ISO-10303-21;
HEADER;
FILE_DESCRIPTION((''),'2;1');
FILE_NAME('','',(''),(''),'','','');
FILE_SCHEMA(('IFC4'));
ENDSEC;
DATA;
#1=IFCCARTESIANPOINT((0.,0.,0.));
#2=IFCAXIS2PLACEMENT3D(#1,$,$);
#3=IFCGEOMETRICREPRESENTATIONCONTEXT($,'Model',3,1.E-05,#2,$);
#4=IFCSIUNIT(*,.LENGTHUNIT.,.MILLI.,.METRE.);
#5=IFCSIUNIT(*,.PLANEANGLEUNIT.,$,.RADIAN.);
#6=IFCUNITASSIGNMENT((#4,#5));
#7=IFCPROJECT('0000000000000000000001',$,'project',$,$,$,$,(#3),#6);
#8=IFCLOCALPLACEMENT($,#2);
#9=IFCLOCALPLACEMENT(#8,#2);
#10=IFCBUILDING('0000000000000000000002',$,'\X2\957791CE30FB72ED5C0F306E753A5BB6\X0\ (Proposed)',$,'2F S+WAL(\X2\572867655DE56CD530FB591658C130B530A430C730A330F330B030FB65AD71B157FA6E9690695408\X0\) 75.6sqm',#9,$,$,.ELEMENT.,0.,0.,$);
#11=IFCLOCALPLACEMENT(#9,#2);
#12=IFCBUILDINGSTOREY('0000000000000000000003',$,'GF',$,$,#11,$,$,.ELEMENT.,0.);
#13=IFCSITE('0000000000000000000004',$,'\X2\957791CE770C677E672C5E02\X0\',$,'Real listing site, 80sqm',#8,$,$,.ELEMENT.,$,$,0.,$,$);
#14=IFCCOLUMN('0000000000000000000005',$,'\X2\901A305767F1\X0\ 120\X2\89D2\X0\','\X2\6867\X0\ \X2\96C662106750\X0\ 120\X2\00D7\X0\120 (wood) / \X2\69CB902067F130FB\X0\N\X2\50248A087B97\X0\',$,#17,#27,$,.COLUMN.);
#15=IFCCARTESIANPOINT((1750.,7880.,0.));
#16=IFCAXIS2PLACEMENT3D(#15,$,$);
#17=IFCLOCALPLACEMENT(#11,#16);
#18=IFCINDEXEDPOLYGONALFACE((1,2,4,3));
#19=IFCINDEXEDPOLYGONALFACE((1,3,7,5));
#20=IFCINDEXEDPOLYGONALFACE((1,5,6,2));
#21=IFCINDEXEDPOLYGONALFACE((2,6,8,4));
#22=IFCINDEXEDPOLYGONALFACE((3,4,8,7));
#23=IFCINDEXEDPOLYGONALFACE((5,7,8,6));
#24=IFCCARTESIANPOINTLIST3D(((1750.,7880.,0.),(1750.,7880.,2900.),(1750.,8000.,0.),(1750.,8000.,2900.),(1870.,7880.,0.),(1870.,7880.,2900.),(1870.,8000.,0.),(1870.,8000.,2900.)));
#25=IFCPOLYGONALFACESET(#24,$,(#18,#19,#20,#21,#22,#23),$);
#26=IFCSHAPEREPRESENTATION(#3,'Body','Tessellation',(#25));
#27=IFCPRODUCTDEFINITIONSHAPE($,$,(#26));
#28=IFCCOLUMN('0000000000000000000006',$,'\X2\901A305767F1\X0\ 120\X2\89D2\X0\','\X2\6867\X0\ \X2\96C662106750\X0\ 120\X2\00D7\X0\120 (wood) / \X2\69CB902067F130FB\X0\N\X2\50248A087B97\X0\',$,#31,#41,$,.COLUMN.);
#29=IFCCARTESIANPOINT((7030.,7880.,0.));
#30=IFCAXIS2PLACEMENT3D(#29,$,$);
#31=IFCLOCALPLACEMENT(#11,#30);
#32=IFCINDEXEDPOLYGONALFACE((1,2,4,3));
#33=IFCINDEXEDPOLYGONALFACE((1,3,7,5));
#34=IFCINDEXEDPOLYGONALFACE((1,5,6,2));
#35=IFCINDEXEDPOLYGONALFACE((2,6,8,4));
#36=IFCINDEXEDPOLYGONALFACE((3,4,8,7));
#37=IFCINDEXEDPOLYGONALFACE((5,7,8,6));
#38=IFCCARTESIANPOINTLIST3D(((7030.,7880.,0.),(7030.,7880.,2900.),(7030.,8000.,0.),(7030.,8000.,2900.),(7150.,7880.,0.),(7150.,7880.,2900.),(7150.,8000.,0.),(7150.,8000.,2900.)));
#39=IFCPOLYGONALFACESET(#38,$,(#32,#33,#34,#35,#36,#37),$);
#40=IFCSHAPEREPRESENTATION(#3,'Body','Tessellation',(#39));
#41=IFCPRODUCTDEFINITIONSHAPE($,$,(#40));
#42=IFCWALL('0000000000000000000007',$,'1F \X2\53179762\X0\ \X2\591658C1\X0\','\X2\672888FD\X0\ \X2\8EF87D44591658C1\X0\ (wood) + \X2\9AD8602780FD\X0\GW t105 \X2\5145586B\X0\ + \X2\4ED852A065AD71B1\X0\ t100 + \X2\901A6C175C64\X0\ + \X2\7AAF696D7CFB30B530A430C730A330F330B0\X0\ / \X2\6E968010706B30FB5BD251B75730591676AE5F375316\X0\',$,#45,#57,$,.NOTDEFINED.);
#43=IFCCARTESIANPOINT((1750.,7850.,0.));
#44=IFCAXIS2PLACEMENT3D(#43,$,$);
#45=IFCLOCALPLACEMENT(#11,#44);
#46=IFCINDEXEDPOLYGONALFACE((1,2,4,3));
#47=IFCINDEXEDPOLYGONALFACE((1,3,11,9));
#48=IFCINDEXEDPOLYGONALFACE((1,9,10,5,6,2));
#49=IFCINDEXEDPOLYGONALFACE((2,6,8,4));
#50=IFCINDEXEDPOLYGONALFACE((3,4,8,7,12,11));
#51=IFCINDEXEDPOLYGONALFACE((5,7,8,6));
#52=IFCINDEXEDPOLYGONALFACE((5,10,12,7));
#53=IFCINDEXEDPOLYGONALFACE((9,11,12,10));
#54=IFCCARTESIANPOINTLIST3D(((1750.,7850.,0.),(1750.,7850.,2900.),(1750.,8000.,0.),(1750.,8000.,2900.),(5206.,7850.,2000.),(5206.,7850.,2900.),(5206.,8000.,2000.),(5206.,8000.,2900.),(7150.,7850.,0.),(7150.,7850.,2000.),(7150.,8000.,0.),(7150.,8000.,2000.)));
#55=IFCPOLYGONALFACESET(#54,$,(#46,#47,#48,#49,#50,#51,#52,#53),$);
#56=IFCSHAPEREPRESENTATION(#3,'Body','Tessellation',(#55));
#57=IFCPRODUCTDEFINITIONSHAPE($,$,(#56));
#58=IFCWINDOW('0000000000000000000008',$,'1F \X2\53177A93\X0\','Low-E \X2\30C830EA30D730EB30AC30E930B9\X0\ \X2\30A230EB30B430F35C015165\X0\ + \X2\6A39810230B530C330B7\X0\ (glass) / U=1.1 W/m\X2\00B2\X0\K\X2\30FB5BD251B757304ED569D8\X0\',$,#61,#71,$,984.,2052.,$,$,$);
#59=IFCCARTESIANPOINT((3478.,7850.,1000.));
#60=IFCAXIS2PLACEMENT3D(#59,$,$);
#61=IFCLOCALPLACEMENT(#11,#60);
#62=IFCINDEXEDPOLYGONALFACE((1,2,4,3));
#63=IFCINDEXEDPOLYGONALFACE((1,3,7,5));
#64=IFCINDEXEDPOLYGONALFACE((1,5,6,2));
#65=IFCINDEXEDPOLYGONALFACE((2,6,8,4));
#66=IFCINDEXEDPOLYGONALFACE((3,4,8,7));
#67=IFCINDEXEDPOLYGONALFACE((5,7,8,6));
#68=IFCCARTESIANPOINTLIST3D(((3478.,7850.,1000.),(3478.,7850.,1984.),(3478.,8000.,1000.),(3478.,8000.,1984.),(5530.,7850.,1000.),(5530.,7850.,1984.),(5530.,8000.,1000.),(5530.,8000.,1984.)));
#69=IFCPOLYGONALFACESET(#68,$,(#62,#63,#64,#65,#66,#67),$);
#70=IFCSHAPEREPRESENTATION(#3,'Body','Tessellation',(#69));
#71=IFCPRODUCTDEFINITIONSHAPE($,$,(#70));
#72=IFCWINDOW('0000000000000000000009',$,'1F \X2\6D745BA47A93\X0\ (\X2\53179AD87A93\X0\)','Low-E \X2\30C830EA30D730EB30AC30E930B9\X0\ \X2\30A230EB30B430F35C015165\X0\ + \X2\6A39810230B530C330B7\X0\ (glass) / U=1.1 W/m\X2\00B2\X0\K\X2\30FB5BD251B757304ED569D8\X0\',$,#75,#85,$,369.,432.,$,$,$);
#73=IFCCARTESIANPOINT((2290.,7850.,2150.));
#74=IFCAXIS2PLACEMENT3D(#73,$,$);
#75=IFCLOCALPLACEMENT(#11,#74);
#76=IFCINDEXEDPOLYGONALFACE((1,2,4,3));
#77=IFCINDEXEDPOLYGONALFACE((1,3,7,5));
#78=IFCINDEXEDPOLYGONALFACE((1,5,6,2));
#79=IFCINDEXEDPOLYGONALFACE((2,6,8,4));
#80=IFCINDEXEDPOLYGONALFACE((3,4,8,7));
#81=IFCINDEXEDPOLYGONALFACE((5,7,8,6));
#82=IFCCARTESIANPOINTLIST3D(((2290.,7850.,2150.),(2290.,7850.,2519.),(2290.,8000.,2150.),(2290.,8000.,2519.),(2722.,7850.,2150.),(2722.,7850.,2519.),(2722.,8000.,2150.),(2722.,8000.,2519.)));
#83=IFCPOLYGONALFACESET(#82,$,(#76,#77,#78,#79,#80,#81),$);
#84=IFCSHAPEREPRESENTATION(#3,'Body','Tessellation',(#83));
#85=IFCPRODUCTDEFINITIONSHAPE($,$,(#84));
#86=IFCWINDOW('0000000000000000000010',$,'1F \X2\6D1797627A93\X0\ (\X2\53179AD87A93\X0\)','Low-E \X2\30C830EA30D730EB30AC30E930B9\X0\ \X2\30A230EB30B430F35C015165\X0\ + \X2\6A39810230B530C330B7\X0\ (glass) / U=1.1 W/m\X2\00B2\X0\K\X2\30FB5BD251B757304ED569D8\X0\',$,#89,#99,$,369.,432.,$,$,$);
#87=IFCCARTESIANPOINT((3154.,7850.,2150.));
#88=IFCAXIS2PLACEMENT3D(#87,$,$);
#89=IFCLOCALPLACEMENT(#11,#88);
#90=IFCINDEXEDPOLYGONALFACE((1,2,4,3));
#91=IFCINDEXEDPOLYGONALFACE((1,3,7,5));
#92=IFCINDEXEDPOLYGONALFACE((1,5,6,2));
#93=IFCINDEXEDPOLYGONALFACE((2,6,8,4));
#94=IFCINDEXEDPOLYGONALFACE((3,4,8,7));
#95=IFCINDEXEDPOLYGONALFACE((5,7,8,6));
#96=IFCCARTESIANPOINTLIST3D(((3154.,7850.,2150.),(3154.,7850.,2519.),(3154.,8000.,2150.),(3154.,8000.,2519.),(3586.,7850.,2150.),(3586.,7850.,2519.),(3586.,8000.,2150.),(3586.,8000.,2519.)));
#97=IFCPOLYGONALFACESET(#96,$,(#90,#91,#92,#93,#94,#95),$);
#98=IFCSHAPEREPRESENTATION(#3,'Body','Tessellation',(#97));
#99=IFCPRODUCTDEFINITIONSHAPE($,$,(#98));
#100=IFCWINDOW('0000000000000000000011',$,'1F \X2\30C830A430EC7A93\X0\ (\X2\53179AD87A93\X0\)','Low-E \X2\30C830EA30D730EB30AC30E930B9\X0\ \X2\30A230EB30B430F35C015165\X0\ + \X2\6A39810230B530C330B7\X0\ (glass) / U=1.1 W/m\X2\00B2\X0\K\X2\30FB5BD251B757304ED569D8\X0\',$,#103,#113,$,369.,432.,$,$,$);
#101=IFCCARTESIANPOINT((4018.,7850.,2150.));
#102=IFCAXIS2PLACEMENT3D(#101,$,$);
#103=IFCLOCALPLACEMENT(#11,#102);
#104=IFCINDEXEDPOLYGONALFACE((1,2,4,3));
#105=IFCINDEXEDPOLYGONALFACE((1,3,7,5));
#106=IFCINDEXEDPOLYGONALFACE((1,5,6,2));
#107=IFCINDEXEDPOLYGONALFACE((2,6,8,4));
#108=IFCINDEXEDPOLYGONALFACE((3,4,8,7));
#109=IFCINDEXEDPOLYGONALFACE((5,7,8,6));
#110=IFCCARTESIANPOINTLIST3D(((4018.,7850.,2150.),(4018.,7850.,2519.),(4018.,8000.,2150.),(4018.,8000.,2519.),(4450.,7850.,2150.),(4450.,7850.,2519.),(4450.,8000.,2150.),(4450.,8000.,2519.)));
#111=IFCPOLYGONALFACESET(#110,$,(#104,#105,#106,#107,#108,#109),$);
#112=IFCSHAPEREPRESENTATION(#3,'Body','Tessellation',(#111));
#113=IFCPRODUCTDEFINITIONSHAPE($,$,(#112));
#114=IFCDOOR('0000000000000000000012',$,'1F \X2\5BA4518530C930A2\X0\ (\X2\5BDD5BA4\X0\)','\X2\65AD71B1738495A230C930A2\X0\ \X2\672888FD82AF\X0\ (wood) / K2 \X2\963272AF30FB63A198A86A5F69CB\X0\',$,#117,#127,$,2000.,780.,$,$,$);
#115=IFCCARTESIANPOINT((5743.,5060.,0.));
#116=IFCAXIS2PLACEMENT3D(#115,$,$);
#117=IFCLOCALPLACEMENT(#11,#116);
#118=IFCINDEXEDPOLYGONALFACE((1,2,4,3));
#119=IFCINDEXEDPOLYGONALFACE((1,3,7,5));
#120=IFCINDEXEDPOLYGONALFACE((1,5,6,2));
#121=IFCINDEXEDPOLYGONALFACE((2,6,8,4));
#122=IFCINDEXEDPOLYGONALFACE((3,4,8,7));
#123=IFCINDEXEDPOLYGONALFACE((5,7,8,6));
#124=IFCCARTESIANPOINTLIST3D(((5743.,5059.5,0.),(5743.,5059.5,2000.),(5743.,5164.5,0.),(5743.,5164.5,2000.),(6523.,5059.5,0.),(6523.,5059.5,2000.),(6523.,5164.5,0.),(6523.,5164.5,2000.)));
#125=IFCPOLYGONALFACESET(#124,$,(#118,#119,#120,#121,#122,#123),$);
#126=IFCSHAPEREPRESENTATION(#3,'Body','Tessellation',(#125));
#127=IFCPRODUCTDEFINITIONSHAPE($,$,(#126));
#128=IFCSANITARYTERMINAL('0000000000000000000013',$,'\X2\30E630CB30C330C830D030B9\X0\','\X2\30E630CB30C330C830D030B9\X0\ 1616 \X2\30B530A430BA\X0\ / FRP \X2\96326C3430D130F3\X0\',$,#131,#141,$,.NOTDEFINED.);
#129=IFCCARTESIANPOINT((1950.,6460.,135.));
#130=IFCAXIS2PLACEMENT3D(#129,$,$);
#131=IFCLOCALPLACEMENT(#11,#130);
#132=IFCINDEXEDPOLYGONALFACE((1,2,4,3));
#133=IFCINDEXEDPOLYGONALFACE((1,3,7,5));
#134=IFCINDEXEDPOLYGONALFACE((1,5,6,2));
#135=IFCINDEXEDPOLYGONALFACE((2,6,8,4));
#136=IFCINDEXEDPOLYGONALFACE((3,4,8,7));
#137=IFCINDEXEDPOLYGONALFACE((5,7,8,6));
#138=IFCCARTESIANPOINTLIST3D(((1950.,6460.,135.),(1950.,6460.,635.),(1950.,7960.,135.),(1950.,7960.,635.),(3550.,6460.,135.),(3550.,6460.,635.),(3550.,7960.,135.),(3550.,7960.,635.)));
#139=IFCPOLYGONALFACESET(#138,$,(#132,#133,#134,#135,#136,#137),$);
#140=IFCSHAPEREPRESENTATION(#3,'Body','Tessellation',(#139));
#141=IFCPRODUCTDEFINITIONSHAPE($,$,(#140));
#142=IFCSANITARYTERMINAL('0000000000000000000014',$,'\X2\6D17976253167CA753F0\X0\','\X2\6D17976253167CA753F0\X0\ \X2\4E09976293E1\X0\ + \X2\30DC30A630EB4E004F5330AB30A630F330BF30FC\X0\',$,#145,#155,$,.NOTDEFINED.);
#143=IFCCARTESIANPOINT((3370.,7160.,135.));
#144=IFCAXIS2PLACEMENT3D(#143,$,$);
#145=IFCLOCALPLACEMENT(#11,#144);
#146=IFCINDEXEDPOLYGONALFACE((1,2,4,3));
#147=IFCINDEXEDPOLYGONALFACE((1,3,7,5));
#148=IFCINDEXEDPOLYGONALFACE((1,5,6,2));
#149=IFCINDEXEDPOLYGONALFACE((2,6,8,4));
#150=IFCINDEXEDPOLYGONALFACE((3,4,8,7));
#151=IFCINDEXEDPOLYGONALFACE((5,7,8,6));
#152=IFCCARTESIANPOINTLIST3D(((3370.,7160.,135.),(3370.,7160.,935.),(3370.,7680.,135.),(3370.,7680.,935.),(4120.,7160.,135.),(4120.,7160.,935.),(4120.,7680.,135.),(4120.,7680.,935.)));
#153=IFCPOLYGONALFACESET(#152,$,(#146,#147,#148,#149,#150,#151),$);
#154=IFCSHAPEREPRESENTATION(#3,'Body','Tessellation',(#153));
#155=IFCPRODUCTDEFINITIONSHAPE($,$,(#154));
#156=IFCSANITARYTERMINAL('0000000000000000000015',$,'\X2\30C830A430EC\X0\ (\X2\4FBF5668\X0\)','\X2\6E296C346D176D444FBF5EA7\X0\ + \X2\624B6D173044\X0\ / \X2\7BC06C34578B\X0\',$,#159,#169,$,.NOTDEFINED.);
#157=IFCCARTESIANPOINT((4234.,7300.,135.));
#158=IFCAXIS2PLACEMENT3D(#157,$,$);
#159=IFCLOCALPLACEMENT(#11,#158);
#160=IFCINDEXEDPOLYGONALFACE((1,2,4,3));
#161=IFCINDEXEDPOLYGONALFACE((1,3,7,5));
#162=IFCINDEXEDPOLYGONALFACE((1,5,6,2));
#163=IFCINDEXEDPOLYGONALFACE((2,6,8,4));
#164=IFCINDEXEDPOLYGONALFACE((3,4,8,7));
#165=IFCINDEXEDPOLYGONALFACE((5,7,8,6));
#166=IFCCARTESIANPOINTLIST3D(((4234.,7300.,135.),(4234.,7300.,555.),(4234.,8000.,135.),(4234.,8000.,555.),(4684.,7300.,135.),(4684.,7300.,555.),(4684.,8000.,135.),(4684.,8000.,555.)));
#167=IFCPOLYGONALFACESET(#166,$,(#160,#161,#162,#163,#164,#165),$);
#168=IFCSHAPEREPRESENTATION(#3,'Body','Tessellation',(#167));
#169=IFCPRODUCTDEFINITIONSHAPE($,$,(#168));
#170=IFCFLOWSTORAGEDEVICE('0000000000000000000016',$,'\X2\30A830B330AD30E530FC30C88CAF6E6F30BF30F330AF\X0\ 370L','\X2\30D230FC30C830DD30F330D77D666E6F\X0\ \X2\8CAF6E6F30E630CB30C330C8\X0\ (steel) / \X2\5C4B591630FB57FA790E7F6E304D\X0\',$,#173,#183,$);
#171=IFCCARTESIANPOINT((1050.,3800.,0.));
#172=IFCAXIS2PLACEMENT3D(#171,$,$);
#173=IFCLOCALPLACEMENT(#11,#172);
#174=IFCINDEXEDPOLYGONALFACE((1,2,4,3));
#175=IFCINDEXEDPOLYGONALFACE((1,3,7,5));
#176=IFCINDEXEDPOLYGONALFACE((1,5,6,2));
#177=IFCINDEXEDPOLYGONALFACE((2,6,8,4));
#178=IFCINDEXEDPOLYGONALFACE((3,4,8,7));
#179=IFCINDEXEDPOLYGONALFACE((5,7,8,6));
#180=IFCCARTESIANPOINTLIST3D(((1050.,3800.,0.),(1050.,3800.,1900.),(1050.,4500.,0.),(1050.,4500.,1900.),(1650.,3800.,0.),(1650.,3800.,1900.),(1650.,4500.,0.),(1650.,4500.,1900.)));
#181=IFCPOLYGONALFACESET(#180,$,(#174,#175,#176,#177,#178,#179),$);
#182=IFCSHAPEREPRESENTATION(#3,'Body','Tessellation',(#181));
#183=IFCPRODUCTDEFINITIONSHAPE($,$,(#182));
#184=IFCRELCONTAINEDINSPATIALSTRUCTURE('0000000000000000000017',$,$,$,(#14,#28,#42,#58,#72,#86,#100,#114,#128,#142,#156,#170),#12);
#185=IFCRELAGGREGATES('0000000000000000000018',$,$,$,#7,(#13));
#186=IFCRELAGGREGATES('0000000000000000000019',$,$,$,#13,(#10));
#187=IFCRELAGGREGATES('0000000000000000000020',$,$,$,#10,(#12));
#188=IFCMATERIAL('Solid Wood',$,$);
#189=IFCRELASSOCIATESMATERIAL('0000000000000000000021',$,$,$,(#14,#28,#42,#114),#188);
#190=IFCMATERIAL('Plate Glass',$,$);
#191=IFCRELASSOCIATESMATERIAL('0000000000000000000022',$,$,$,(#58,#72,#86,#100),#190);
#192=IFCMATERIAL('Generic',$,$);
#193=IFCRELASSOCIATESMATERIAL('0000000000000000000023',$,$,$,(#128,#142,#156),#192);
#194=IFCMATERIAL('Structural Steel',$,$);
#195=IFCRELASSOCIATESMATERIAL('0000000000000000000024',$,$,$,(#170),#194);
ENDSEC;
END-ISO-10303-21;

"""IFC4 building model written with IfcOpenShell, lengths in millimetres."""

from ifc_helpers import new_model, si_unit, frame, frame_2d, origin, place, context, project, spatial, rectangle, extrude, material, element, fill, save


model = new_model("IFC4")

# Units and contexts
model_context = context("Model", 3, precision=1e-05, world=origin())
ifc_project = project(units=[si_unit("LENGTHUNIT", "METRE", prefix="MILLI"), si_unit("PLANEANGLEUNIT", "RADIAN")], contexts=[model_context])

# Site, building, storey
site_placement = place(None, origin())
site = spatial("IfcSite", under=ifc_project, at=site_placement, Name="長野県松本市", ObjectType="Real listing site, 80sqm", CompositionType="ELEMENT", RefElevation=0.0)
building_placement = place(site_placement, origin())
building = spatial("IfcBuilding", under=site, at=building_placement, Name="長野・狭小の町家 (Proposed)", ObjectType="2F S+WAL(在来工法・外壁サイディング・断熱基準適合) 75.6sqm", CompositionType="ELEMENT", ElevationOfRefHeight=0.0, ElevationOfTerrain=0.0)
storey_placement = place(building_placement, origin())
storey = spatial("IfcBuildingStorey", under=building, at=storey_placement, Name="GF", CompositionType="ELEMENT", Elevation=0.0)

# Columns
ifc_material_1 = material(Name="Solid Wood")
column_1_placement = place(storey_placement, frame((1750.0, 7880.0, 0.0)))
element("IfcColumn", 1, at=column_1_placement, inside=storey, material=ifc_material_1, Name="通し柱 120角", Description="桧 集成材 120×120 (wood) / 構造柱・N値計算", PredefinedType="COLUMN", context=model_context, shape_type="SweptSolid", body=[
    extrude(rectangle(XDim=120.0, YDim=120.0, at=frame_2d((60.0, 60.0))), frame((1750.0, 7880.0, 0.0)), (0.0, 0.0, 1.0), 2900.0),
])
column_2_placement = place(storey_placement, frame((7030.0, 7880.0, 0.0)))
element("IfcColumn", 2, at=column_2_placement, inside=storey, material=ifc_material_1, Name="通し柱 120角", Description="桧 集成材 120×120 (wood) / 構造柱・N値計算", PredefinedType="COLUMN", context=model_context, shape_type="SweptSolid", body=[
    extrude(rectangle(XDim=120.0, YDim=120.0, at=frame_2d((60.0, 60.0))), frame((7030.0, 7880.0, 0.0)), (0.0, 0.0, 1.0), 2900.0),
])

# Wall, openings, windows
wall_1_placement = place(storey_placement, frame((1750.0, 7850.0, 0.0)))
wall_1 = element("IfcWall", 3, at=wall_1_placement, inside=storey, material=ifc_material_1, Name="1F 北面 外壁", Description="木製 軸組外壁 (wood) + 高性能GW t105 充填 + 付加断熱 t100 + 通気層 + 窯業系サイディング / 準耐火・寒冷地外皮強化", PredefinedType="NOTDEFINED", context=model_context, shape_type="SweptSolid", body=[
    extrude(rectangle(XDim=5400.0, YDim=150.0, at=frame_2d((2700.0, 75.0))), frame((1750.0, 7850.0, 0.0)), (0.0, 0.0, 1.0), 2900.0),
])
opening_1_placement = place(storey_placement, frame((3478.0, 7850.0, 1000.0)))
opening_1 = element("IfcOpeningElement", 4, at=opening_1_placement, cuts=wall_1, PredefinedType="NOTDEFINED", context=model_context, shape_type="SweptSolid", body=[
    extrude(rectangle(XDim=2052.0, YDim=150.0, at=frame_2d((1026.0, 75.0))), frame((3478.0, 7850.0, 1000.0)), (0.0, 0.0, 1.0), 984.0),
])
opening_2_placement = place(storey_placement, frame((2290.0, 7850.0, 2150.0)))
opening_2 = element("IfcOpeningElement", 5, at=opening_2_placement, cuts=wall_1, PredefinedType="NOTDEFINED", context=model_context, shape_type="SweptSolid", body=[
    extrude(rectangle(XDim=432.0, YDim=150.0, at=frame_2d((216.0, 75.0))), frame((2290.0, 7850.0, 2150.0)), (0.0, 0.0, 1.0), 369.0),
])
opening_3_placement = place(storey_placement, frame((3154.0, 7850.0, 2150.0)))
opening_3 = element("IfcOpeningElement", 6, at=opening_3_placement, cuts=wall_1, PredefinedType="NOTDEFINED", context=model_context, shape_type="SweptSolid", body=[
    extrude(rectangle(XDim=432.0, YDim=150.0, at=frame_2d((216.0, 75.0))), frame((3154.0, 7850.0, 2150.0)), (0.0, 0.0, 1.0), 369.0),
])
opening_4_placement = place(storey_placement, frame((4018.0, 7850.0, 2150.0)))
opening_4 = element("IfcOpeningElement", 7, at=opening_4_placement, cuts=wall_1, PredefinedType="NOTDEFINED", context=model_context, shape_type="SweptSolid", body=[
    extrude(rectangle(XDim=432.0, YDim=150.0, at=frame_2d((216.0, 75.0))), frame((4018.0, 7850.0, 2150.0)), (0.0, 0.0, 1.0), 369.0),
])
ifc_material_2 = material(Name="Plate Glass")
window_1_placement = place(storey_placement, frame((3478.0, 7850.0, 1000.0)))
window_1 = element("IfcWindow", 8, at=window_1_placement, inside=storey, material=ifc_material_2, Name="1F 北窓", Description="Low-E トリプルガラス アルゴン封入 + 樹脂サッシ (glass) / U=1.1 W/m²K・寒冷地仕様", OverallHeight=984.0, OverallWidth=2052.0, context=model_context, shape_type="SweptSolid", body=[
    extrude(rectangle(XDim=2052.0, YDim=150.0, at=frame_2d((1026.0, 75.0))), frame((3478.0, 7850.0, 1000.0)), (0.0, 0.0, 1.0), 984.0),
])
fill(opening_1, window_1)
window_2_placement = place(storey_placement, frame((2290.0, 7850.0, 2150.0)))
window_2 = element("IfcWindow", 9, at=window_2_placement, inside=storey, material=ifc_material_2, Name="1F 浴室窓 (北高窓)", Description="Low-E トリプルガラス アルゴン封入 + 樹脂サッシ (glass) / U=1.1 W/m²K・寒冷地仕様", OverallHeight=369.0, OverallWidth=432.0, context=model_context, shape_type="SweptSolid", body=[
    extrude(rectangle(XDim=432.0, YDim=150.0, at=frame_2d((216.0, 75.0))), frame((2290.0, 7850.0, 2150.0)), (0.0, 0.0, 1.0), 369.0),
])
fill(opening_2, window_2)
window_3_placement = place(storey_placement, frame((3154.0, 7850.0, 2150.0)))
window_3 = element("IfcWindow", 10, at=window_3_placement, inside=storey, material=ifc_material_2, Name="1F 洗面窓 (北高窓)", Description="Low-E トリプルガラス アルゴン封入 + 樹脂サッシ (glass) / U=1.1 W/m²K・寒冷地仕様", OverallHeight=369.0, OverallWidth=432.0, context=model_context, shape_type="SweptSolid", body=[
    extrude(rectangle(XDim=432.0, YDim=150.0, at=frame_2d((216.0, 75.0))), frame((3154.0, 7850.0, 2150.0)), (0.0, 0.0, 1.0), 369.0),
])
fill(opening_3, window_3)
window_4_placement = place(storey_placement, frame((4018.0, 7850.0, 2150.0)))
window_4 = element("IfcWindow", 11, at=window_4_placement, inside=storey, material=ifc_material_2, Name="1F トイレ窓 (北高窓)", Description="Low-E トリプルガラス アルゴン封入 + 樹脂サッシ (glass) / U=1.1 W/m²K・寒冷地仕様", OverallHeight=369.0, OverallWidth=432.0, context=model_context, shape_type="SweptSolid", body=[
    extrude(rectangle(XDim=432.0, YDim=150.0, at=frame_2d((216.0, 75.0))), frame((4018.0, 7850.0, 2150.0)), (0.0, 0.0, 1.0), 369.0),
])
fill(opening_4, window_4)

# Door
door_1_placement = place(storey_placement, frame((5743.0, 5060.0, 0.0)))
element("IfcDoor", 12, at=door_1_placement, inside=storey, material=ifc_material_1, Name="1F 室内ドア (寝室)", Description="断熱玄関ドア 木製芯 (wood) / K2 防犯・採風機構", OverallHeight=2000.0, OverallWidth=780.0, context=model_context, shape_type="SweptSolid", body=[
    extrude(rectangle(XDim=780.0, YDim=105.0, at=frame_2d((390.0, 52.0))), frame((5743.0, 5060.0, 0.0)), (0.0, 0.0, 1.0), 2000.0),
])

# Sanitary terminals
ifc_material_3 = material(Name="Generic")
sanitary_terminal_1_placement = place(storey_placement, frame((1950.0, 6460.0, 135.0)))
element("IfcSanitaryTerminal", 13, at=sanitary_terminal_1_placement, inside=storey, material=ifc_material_3, Name="ユニットバス", Description="ユニットバス 1616 サイズ / FRP 防水パン", PredefinedType="NOTDEFINED", context=model_context, shape_type="SweptSolid", body=[
    extrude(rectangle(XDim=1600.0, YDim=1500.0, at=frame_2d((800.0, 750.0))), frame((1950.0, 6460.0, 135.0)), (0.0, 0.0, 1.0), 500.0),
])
sanitary_terminal_2_placement = place(storey_placement, frame((3370.0, 7160.0, 135.0)))
element("IfcSanitaryTerminal", 14, at=sanitary_terminal_2_placement, inside=storey, material=ifc_material_3, Name="洗面化粧台", Description="洗面化粧台 三面鏡 + ボウル一体カウンター", PredefinedType="NOTDEFINED", context=model_context, shape_type="SweptSolid", body=[
    extrude(rectangle(XDim=750.0, YDim=520.0, at=frame_2d((375.0, 260.0))), frame((3370.0, 7160.0, 135.0)), (0.0, 0.0, 1.0), 800.0),
])
sanitary_terminal_3_placement = place(storey_placement, frame((4234.0, 7300.0, 135.0)))
element("IfcSanitaryTerminal", 15, at=sanitary_terminal_3_placement, inside=storey, material=ifc_material_3, Name="トイレ (便器)", Description="温水洗浄便座 + 手洗い / 節水型", PredefinedType="NOTDEFINED", context=model_context, shape_type="SweptSolid", body=[
    extrude(rectangle(XDim=450.0, YDim=700.0, at=frame_2d((225.0, 350.0))), frame((4234.0, 7300.0, 135.0)), (0.0, 0.0, 1.0), 420.0),
])

# Flow storage device
ifc_material_4 = material(Name="Structural Steel")
flow_storage_device_placement = place(storey_placement, frame((1050.0, 3800.0, 0.0)))
element("IfcFlowStorageDevice", 16, at=flow_storage_device_placement, inside=storey, material=ifc_material_4, Name="エコキュート貯湯タンク 370L", Description="ヒートポンプ給湯 貯湯ユニット (steel) / 屋外・基礎置き", context=model_context, shape_type="SweptSolid", body=[
    extrude(rectangle(XDim=600.0, YDim=700.0, at=frame_2d((300.0, 350.0))), frame((1050.0, 3800.0, 0.0)), (0.0, 0.0, 1.0), 1900.0),
])

save(model, "model.ifc")
